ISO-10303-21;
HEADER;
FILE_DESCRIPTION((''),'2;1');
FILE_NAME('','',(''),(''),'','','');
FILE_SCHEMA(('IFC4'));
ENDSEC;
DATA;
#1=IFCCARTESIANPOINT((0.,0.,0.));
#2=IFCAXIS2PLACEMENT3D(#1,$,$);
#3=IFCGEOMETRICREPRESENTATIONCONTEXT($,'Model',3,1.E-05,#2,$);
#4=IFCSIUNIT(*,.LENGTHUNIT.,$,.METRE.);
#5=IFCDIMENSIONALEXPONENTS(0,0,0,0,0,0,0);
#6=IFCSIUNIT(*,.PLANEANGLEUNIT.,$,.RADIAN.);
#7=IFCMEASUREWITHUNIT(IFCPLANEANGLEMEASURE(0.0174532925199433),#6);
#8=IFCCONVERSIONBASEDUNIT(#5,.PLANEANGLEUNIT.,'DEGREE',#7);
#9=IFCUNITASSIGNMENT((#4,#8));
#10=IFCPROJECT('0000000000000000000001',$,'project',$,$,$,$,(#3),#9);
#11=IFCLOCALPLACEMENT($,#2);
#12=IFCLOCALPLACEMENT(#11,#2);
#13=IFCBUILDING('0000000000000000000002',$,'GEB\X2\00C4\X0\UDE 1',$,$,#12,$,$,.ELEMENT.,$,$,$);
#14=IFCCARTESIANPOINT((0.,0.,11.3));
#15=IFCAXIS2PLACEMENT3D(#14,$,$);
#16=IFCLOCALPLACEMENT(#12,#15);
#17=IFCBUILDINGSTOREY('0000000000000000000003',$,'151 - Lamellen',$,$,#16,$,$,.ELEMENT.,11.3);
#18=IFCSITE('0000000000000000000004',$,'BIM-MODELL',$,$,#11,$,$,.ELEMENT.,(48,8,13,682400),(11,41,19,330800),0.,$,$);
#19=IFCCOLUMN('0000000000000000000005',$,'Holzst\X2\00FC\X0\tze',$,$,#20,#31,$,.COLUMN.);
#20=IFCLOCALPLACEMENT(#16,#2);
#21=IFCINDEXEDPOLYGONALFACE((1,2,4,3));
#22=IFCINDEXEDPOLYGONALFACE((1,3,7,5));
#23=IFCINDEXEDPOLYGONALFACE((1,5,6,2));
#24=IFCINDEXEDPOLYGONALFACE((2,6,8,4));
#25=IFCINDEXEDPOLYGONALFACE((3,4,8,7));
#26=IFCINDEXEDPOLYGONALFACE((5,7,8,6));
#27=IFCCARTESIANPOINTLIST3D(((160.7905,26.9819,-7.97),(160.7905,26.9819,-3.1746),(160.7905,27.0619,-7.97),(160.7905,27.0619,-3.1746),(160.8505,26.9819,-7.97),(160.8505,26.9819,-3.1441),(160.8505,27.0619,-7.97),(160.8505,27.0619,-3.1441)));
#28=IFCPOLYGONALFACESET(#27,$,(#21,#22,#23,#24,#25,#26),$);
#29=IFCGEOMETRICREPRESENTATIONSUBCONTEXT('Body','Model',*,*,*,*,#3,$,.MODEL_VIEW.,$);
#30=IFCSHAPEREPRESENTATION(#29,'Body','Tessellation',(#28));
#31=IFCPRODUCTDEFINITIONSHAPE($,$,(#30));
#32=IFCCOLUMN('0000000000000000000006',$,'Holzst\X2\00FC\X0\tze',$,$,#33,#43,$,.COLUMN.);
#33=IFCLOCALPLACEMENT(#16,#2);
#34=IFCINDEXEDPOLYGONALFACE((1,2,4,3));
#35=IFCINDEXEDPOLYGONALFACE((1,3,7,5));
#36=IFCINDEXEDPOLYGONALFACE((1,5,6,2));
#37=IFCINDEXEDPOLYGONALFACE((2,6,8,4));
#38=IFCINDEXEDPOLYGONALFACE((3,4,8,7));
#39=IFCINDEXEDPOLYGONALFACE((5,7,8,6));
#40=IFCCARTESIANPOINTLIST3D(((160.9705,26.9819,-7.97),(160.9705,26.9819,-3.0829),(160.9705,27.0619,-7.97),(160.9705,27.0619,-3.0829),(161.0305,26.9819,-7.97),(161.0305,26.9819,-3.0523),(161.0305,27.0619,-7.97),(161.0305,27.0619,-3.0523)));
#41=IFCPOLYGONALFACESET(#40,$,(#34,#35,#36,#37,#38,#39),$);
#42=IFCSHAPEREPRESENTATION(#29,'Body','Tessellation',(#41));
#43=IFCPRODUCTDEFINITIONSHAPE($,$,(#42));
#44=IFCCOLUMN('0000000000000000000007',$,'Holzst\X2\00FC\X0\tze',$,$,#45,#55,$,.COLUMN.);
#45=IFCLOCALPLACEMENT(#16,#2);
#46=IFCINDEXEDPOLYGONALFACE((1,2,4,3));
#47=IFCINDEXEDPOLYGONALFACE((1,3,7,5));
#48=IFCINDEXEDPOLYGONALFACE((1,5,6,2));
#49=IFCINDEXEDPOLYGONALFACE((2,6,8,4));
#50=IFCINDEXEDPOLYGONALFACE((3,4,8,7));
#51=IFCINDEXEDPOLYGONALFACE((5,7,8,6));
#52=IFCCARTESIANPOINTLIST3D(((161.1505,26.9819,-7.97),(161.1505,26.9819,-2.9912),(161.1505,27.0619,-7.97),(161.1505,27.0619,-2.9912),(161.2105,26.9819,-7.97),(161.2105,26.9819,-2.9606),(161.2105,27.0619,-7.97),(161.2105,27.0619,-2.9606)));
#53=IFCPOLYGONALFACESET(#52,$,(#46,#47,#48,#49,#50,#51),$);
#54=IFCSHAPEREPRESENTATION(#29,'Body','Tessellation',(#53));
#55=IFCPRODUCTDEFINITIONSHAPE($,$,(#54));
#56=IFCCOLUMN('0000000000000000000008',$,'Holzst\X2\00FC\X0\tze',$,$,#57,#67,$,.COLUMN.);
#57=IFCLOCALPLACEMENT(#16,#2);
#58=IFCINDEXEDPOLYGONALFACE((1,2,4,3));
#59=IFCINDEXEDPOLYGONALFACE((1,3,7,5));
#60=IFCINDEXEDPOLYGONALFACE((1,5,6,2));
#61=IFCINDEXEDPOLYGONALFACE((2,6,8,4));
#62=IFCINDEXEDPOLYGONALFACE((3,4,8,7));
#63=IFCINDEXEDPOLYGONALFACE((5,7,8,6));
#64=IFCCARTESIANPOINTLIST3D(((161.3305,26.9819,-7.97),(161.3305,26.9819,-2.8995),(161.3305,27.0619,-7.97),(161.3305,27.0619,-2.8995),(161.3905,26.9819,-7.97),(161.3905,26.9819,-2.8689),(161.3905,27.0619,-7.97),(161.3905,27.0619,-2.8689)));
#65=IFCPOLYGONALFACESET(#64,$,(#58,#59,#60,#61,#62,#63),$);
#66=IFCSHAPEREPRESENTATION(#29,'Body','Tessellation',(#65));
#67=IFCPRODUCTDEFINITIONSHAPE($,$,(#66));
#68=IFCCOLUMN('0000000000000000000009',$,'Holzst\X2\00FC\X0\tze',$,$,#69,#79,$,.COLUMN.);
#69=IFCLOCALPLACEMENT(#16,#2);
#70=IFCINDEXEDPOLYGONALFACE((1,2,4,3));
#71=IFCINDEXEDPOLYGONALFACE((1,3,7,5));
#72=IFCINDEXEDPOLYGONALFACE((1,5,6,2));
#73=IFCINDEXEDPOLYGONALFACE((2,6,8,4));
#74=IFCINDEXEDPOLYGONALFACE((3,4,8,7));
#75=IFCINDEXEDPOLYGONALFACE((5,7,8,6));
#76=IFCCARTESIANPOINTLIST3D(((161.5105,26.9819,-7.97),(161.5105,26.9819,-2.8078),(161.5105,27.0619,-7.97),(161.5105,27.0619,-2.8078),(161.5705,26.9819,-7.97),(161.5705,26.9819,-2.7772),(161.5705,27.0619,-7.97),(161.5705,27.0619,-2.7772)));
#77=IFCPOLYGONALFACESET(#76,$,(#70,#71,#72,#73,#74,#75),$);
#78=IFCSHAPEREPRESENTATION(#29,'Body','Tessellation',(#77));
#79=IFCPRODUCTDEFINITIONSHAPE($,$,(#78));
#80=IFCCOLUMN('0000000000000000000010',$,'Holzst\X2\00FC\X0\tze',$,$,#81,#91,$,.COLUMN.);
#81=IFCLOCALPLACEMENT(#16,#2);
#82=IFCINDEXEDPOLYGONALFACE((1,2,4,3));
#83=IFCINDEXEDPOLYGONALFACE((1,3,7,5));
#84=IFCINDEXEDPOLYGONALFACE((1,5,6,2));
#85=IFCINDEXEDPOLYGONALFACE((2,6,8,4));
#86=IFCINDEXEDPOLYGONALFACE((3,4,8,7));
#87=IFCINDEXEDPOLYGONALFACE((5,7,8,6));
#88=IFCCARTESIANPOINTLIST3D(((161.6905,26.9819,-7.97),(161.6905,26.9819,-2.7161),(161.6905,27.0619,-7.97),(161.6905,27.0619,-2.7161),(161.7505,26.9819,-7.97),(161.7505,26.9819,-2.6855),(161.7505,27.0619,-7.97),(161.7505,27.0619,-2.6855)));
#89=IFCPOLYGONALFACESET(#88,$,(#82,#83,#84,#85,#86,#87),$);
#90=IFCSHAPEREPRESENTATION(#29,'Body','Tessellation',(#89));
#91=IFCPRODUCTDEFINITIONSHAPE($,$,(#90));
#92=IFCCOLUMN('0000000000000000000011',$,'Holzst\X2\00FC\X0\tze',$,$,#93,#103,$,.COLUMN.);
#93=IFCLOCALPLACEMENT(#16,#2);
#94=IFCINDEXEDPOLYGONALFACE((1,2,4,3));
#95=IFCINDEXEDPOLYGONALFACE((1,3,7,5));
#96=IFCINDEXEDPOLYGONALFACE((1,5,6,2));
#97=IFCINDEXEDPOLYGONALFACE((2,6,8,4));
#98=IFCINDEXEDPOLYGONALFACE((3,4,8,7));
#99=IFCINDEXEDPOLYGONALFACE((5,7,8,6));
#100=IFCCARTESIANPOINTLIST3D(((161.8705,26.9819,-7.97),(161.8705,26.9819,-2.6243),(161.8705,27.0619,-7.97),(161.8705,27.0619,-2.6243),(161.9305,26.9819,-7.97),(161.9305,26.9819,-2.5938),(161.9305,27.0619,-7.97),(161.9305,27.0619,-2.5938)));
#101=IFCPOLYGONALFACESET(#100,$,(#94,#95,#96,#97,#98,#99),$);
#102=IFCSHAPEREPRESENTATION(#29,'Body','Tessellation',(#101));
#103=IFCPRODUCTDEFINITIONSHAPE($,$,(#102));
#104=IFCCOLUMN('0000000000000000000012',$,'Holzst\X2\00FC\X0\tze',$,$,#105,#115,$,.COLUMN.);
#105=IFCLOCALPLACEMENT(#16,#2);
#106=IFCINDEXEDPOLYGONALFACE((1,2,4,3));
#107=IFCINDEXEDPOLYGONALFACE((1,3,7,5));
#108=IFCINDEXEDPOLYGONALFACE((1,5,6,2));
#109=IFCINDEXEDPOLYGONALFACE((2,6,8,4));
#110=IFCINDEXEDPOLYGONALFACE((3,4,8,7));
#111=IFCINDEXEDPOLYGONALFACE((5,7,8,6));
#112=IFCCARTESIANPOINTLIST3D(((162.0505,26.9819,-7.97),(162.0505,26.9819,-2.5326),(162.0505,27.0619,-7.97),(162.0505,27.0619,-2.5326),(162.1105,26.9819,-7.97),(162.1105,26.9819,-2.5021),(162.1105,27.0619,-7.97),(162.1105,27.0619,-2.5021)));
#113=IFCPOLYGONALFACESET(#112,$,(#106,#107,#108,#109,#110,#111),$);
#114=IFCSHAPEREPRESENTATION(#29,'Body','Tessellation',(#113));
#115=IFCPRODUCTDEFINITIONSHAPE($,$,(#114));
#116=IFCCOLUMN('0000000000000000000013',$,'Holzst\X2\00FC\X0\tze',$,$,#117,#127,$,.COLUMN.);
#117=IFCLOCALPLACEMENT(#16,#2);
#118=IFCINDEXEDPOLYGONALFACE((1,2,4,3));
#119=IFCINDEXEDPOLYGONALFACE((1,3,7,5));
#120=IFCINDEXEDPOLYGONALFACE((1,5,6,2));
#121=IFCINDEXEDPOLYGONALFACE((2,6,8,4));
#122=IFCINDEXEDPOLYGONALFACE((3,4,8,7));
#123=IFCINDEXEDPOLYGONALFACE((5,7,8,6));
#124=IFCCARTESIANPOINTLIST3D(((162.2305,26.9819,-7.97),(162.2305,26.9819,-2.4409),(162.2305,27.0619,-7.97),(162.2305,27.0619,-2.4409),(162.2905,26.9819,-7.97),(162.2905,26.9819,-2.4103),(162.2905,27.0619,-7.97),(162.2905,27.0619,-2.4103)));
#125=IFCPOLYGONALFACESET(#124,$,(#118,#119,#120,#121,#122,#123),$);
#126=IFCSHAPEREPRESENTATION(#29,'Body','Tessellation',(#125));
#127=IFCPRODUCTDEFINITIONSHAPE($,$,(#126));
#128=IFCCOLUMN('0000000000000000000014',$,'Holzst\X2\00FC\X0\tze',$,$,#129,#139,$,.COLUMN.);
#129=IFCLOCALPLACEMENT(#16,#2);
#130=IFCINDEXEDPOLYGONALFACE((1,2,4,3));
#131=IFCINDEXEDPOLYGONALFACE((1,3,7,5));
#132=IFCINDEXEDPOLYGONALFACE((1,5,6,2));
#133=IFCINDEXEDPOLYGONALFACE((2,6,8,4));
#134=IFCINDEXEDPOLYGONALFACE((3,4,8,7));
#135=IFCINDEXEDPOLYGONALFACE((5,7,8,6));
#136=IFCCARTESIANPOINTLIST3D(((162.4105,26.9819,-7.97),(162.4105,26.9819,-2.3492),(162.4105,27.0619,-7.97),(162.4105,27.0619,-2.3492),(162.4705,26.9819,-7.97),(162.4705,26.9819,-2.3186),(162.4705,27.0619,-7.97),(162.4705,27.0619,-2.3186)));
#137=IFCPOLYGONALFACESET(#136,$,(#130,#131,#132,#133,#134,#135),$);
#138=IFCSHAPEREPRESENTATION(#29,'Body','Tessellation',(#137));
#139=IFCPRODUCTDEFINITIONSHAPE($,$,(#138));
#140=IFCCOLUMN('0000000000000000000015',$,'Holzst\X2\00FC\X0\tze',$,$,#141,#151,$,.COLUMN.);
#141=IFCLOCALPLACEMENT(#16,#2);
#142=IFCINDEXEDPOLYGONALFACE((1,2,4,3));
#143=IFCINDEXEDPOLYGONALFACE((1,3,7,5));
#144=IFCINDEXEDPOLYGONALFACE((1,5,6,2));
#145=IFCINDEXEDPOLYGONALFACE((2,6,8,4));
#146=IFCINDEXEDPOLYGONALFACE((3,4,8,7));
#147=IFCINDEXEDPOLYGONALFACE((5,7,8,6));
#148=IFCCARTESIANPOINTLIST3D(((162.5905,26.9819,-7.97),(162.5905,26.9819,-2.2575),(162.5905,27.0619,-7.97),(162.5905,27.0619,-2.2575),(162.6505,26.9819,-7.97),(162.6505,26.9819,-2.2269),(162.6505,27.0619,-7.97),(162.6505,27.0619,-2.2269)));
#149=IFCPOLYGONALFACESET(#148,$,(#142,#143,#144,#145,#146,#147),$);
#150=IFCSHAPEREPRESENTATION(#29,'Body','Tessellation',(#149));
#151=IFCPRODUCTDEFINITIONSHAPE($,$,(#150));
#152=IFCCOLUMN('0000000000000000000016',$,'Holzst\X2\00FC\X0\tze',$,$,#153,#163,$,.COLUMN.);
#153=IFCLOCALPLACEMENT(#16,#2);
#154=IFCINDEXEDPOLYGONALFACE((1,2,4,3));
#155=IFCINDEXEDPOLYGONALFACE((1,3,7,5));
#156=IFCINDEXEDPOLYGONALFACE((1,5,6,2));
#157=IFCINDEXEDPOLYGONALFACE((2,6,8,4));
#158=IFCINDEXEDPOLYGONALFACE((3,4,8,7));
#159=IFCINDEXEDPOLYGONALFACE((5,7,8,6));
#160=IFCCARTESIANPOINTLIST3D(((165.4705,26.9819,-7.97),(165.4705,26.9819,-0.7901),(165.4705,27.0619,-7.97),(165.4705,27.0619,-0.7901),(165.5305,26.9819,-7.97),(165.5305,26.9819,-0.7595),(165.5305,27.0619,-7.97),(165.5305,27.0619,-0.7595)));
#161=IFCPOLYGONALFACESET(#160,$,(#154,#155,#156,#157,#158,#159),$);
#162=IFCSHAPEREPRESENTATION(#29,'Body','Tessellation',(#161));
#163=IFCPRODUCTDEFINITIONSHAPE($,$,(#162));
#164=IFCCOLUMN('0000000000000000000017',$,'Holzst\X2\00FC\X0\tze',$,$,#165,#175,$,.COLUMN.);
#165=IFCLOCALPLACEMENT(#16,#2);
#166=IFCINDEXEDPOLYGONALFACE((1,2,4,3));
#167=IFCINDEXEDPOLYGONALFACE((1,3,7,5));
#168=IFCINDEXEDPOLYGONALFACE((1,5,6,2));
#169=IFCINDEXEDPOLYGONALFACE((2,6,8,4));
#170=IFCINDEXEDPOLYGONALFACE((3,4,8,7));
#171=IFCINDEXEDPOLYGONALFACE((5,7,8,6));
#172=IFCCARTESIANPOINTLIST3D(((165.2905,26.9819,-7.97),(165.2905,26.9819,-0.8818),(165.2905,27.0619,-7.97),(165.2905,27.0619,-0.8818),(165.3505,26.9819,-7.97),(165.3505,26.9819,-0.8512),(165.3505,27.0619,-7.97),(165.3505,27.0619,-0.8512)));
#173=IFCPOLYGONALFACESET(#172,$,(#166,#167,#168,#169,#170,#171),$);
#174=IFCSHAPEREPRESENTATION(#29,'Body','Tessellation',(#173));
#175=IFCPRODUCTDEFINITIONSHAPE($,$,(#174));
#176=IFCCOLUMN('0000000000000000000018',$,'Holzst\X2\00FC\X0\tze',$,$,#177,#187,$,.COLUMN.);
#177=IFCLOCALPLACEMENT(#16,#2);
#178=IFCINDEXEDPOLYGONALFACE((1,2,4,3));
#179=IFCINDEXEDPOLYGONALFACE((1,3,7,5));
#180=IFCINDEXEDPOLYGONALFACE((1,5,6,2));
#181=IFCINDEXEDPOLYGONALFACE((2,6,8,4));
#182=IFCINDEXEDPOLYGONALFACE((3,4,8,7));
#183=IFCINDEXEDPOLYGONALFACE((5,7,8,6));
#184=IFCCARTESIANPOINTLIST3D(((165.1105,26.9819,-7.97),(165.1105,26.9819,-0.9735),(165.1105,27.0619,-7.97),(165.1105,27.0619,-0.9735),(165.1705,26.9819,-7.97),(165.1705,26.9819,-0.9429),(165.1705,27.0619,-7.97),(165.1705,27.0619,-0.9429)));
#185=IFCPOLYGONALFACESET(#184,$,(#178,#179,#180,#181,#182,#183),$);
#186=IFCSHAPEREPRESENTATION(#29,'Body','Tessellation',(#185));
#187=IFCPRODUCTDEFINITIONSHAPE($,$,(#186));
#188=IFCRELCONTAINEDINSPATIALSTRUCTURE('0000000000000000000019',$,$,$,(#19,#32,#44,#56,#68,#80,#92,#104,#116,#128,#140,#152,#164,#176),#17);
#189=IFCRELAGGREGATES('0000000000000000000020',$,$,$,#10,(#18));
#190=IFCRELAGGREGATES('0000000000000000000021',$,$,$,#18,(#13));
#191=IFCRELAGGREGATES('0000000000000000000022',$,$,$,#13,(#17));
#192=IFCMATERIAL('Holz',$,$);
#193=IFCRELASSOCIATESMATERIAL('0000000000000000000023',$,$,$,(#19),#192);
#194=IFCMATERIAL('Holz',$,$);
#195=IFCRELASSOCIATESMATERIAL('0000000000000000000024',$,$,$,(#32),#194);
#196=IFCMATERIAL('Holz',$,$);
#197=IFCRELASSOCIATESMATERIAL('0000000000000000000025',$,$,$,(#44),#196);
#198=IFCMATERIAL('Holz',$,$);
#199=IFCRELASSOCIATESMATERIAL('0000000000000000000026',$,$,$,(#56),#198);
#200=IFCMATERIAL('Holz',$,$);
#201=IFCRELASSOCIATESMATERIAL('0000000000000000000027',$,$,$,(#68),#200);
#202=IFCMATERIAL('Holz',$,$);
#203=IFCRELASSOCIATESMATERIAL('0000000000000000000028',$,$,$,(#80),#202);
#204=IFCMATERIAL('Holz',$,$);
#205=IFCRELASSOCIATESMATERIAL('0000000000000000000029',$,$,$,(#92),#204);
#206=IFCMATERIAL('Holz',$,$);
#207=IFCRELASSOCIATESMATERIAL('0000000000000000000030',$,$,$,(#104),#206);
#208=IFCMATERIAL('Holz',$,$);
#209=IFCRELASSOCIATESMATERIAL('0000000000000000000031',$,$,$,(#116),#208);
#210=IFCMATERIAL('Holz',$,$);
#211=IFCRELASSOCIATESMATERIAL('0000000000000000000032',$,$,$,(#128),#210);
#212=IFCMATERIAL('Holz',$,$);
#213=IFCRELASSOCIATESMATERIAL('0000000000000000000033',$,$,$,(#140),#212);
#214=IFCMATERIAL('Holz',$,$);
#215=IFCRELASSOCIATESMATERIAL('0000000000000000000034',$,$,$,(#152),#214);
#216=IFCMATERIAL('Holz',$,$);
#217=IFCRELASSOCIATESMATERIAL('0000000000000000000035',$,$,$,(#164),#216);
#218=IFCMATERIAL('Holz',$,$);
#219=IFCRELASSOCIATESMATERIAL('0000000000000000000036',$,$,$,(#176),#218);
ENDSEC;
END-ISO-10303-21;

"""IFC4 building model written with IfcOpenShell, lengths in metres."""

from ifc_helpers import new_model, entity, si_unit, converted_unit, frame, frame_2d, origin, origin_with_axes, place, context, subcontext, project, spatial, rectangle, extrude, clip, halfspace, material, element, save


model = new_model("IFC4")

# Units and contexts
model_context = context("Model", 3, precision=1e-05, world=origin())
body_context = subcontext(model_context, "Body", "Model", "MODEL_VIEW")
ifc_project = project(units=[si_unit("LENGTHUNIT", "METRE"), converted_unit("PLANEANGLEUNIT", "DEGREE", entity("IfcPlaneAngleMeasure", 0.0174532925199433), si_unit("PLANEANGLEUNIT", "RADIAN"), dimensions=[0, 0, 0, 0, 0, 0, 0])], contexts=[model_context])

# Site, building, storey
site_placement = place(None, origin())
site = spatial("IfcSite", under=ifc_project, at=site_placement, Name="BIM-MODELL", CompositionType="ELEMENT", RefLatitude=(48, 8, 13, 682400), RefLongitude=(11, 41, 19, 330800), RefElevation=0.0)
building_placement = place(site_placement, origin())
building = spatial("IfcBuilding", under=site, at=building_placement, Name="GEBÄUDE 1", CompositionType="ELEMENT")
storey_placement = place(building_placement, frame((0.0, 0.0, 11.3)))
storey = spatial("IfcBuildingStorey", under=building, at=storey_placement, Name="151 - Lamellen", CompositionType="ELEMENT", Elevation=11.3)

# Columns
ifc_material_1 = material(Name="Holz")
column_1_placement = place(storey_placement, frame((160.7905, 26.9819, -7.97)))
element("IfcColumn", 1, at=column_1_placement, inside=storey, material=ifc_material_1, Name="Holzstütze", PredefinedType="COLUMN", context=body_context, shape_type="Clipping", body=[
    clip(extrude(rectangle(XDim=0.06, YDim=0.08, at=frame_2d((0.03, 0.04), x_axis=(1.0, 0.0))), origin_with_axes(), (0.0, 0.0, 1.0), 4.8259), halfspace(frame((0.03, 0.04, 4.8107), z_axis=(0.45399, 0.0, -0.891007), x_axis=(0.0, -1.0, 0.0)), True)),
])
ifc_material_2 = material(Name="Holz")
column_2_placement = place(storey_placement, frame((160.9705, 26.9819, -7.97)))
element("IfcColumn", 2, at=column_2_placement, inside=storey, material=ifc_material_2, Name="Holzstütze", PredefinedType="COLUMN", context=body_context, shape_type="Clipping", body=[
    clip(extrude(rectangle(XDim=0.06, YDim=0.08, at=frame_2d((0.03, 0.04), x_axis=(1.0, 0.0))), origin_with_axes(), (0.0, 0.0, 1.0), 4.9177), halfspace(frame((0.03, 0.04, 4.9024), z_axis=(0.45399, 0.0, -0.891007), x_axis=(0.0, -1.0, 0.0)), True)),
])
ifc_material_3 = material(Name="Holz")
column_3_placement = place(storey_placement, frame((161.1505, 26.9819, -7.97)))
element("IfcColumn", 3, at=column_3_placement, inside=storey, material=ifc_material_3, Name="Holzstütze", PredefinedType="COLUMN", context=body_context, shape_type="Clipping", body=[
    clip(extrude(rectangle(XDim=0.06, YDim=0.08, at=frame_2d((0.03, 0.04), x_axis=(1.0, 0.0))), origin_with_axes(), (0.0, 0.0, 1.0), 5.0094), halfspace(frame((0.03, 0.04, 4.9941), z_axis=(0.45399, 0.0, -0.891007), x_axis=(0.0, -1.0, 0.0)), True)),
])
ifc_material_4 = material(Name="Holz")
column_4_placement = place(storey_placement, frame((161.3305, 26.9819, -7.97)))
element("IfcColumn", 4, at=column_4_placement, inside=storey, material=ifc_material_4, Name="Holzstütze", PredefinedType="COLUMN", context=body_context, shape_type="Clipping", body=[
    clip(extrude(rectangle(XDim=0.06, YDim=0.08, at=frame_2d((0.03, 0.04), x_axis=(1.0, 0.0))), origin_with_axes(), (0.0, 0.0, 1.0), 5.1011), halfspace(frame((0.03, 0.04, 5.0858), z_axis=(0.45399, 0.0, -0.891007), x_axis=(0.0, -1.0, 0.0)), True)),
])
ifc_material_5 = material(Name="Holz")
column_5_placement = place(storey_placement, frame((161.5105, 26.9819, -7.97)))
element("IfcColumn", 5, at=column_5_placement, inside=storey, material=ifc_material_5, Name="Holzstütze", PredefinedType="COLUMN", context=body_context, shape_type="Clipping", body=[
    clip(extrude(rectangle(XDim=0.06, YDim=0.08, at=frame_2d((0.03, 0.04), x_axis=(1.0, 0.0))), origin_with_axes(), (0.0, 0.0, 1.0), 5.1928), halfspace(frame((0.03, 0.04, 5.1775), z_axis=(0.45399, 0.0, -0.891007), x_axis=(0.0, -1.0, 0.0)), True)),
])
ifc_material_6 = material(Name="Holz")
column_6_placement = place(storey_placement, frame((161.6905, 26.9819, -7.97)))
element("IfcColumn", 6, at=column_6_placement, inside=storey, material=ifc_material_6, Name="Holzstütze", PredefinedType="COLUMN", context=body_context, shape_type="Clipping", body=[
    clip(extrude(rectangle(XDim=0.06, YDim=0.08, at=frame_2d((0.03, 0.04), x_axis=(1.0, 0.0))), origin_with_axes(), (0.0, 0.0, 1.0), 5.2845), halfspace(frame((0.03, 0.04, 5.2692), z_axis=(0.45399, 0.0, -0.891007), x_axis=(0.0, -1.0, 0.0)), True)),
])
ifc_material_7 = material(Name="Holz")
column_7_placement = place(storey_placement, frame((161.8705, 26.9819, -7.97)))
element("IfcColumn", 7, at=column_7_placement, inside=storey, material=ifc_material_7, Name="Holzstütze", PredefinedType="COLUMN", context=body_context, shape_type="Clipping", body=[
    clip(extrude(rectangle(XDim=0.06, YDim=0.08, at=frame_2d((0.03, 0.04), x_axis=(1.0, 0.0))), origin_with_axes(), (0.0, 0.0, 1.0), 5.3762), halfspace(frame((0.03, 0.04, 5.3609), z_axis=(0.45399, 0.0, -0.891007), x_axis=(0.0, -1.0, 0.0)), True)),
])
ifc_material_8 = material(Name="Holz")
column_8_placement = place(storey_placement, frame((162.0505, 26.9819, -7.97)))
element("IfcColumn", 8, at=column_8_placement, inside=storey, material=ifc_material_8, Name="Holzstütze", PredefinedType="COLUMN", context=body_context, shape_type="Clipping", body=[
    clip(extrude(rectangle(XDim=0.06, YDim=0.08, at=frame_2d((0.03, 0.04), x_axis=(1.0, 0.0))), origin_with_axes(), (0.0, 0.0, 1.0), 5.4679), halfspace(frame((0.03, 0.04, 5.4527), z_axis=(0.45399, 0.0, -0.891007), x_axis=(0.0, -1.0, 0.0)), True)),
])
ifc_material_9 = material(Name="Holz")
column_9_placement = place(storey_placement, frame((162.2305, 26.9819, -7.97)))
element("IfcColumn", 9, at=column_9_placement, inside=storey, material=ifc_material_9, Name="Holzstütze", PredefinedType="COLUMN", context=body_context, shape_type="Clipping", body=[
    clip(extrude(rectangle(XDim=0.06, YDim=0.08, at=frame_2d((0.03, 0.04), x_axis=(1.0, 0.0))), origin_with_axes(), (0.0, 0.0, 1.0), 5.5597), halfspace(frame((0.03, 0.04, 5.5444), z_axis=(0.45399, 0.0, -0.891007), x_axis=(0.0, -1.0, 0.0)), True)),
])
ifc_material_10 = material(Name="Holz")
column_10_placement = place(storey_placement, frame((162.4105, 26.9819, -7.97)))
element("IfcColumn", 10, at=column_10_placement, inside=storey, material=ifc_material_10, Name="Holzstütze", PredefinedType="COLUMN", context=body_context, shape_type="Clipping", body=[
    clip(extrude(rectangle(XDim=0.06, YDim=0.08, at=frame_2d((0.03, 0.04), x_axis=(1.0, 0.0))), origin_with_axes(), (0.0, 0.0, 1.0), 5.6514), halfspace(frame((0.03, 0.04, 5.6361), z_axis=(0.45399, 0.0, -0.891007), x_axis=(0.0, -1.0, 0.0)), True)),
])
ifc_material_11 = material(Name="Holz")
column_11_placement = place(storey_placement, frame((162.5905, 26.9819, -7.97)))
element("IfcColumn", 11, at=column_11_placement, inside=storey, material=ifc_material_11, Name="Holzstütze", PredefinedType="COLUMN", context=body_context, shape_type="Clipping", body=[
    clip(extrude(rectangle(XDim=0.06, YDim=0.08, at=frame_2d((0.03, 0.04), x_axis=(1.0, 0.0))), origin_with_axes(), (0.0, 0.0, 1.0), 5.7431), halfspace(frame((0.03, 0.04, 5.7278), z_axis=(0.45399, 0.0, -0.891007), x_axis=(0.0, -1.0, 0.0)), True)),
])
ifc_material_12 = material(Name="Holz")
column_12_placement = place(storey_placement, frame((165.4705, 26.9819, -7.97)))
element("IfcColumn", 12, at=column_12_placement, inside=storey, material=ifc_material_12, Name="Holzstütze", PredefinedType="COLUMN", context=body_context, shape_type="Clipping", body=[
    clip(extrude(rectangle(XDim=0.06, YDim=0.08, at=frame_2d((0.03, 0.04), x_axis=(1.0, 0.0))), origin_with_axes(), (0.0, 0.0, 1.0), 7.2105), halfspace(frame((0.03, 0.04, 7.1952), z_axis=(0.45399, 0.0, -0.891007), x_axis=(0.0, -1.0, 0.0)), True)),
])
ifc_material_13 = material(Name="Holz")
column_13_placement = place(storey_placement, frame((165.2905, 26.9819, -7.97)))
element("IfcColumn", 13, at=column_13_placement, inside=storey, material=ifc_material_13, Name="Holzstütze", PredefinedType="COLUMN", context=body_context, shape_type="Clipping", body=[
    clip(extrude(rectangle(XDim=0.06, YDim=0.08, at=frame_2d((0.03, 0.04), x_axis=(1.0, 0.0))), origin_with_axes(), (0.0, 0.0, 1.0), 7.1188), halfspace(frame((0.03, 0.04, 7.1035), z_axis=(0.45399, 0.0, -0.891007), x_axis=(0.0, -1.0, 0.0)), True)),
])
ifc_material_14 = material(Name="Holz")
column_14_placement = place(storey_placement, frame((165.1105, 26.9819, -7.97)))
element("IfcColumn", 14, at=column_14_placement, inside=storey, material=ifc_material_14, Name="Holzstütze", PredefinedType="COLUMN", context=body_context, shape_type="Clipping", body=[
    clip(extrude(rectangle(XDim=0.06, YDim=0.08, at=frame_2d((0.03, 0.04), x_axis=(1.0, 0.0))), origin_with_axes(), (0.0, 0.0, 1.0), 7.0271), halfspace(frame((0.03, 0.04, 7.0118), z_axis=(0.45399, 0.0, -0.891007), x_axis=(0.0, -1.0, 0.0)), True)),
])

save(model, "model.ifc")
